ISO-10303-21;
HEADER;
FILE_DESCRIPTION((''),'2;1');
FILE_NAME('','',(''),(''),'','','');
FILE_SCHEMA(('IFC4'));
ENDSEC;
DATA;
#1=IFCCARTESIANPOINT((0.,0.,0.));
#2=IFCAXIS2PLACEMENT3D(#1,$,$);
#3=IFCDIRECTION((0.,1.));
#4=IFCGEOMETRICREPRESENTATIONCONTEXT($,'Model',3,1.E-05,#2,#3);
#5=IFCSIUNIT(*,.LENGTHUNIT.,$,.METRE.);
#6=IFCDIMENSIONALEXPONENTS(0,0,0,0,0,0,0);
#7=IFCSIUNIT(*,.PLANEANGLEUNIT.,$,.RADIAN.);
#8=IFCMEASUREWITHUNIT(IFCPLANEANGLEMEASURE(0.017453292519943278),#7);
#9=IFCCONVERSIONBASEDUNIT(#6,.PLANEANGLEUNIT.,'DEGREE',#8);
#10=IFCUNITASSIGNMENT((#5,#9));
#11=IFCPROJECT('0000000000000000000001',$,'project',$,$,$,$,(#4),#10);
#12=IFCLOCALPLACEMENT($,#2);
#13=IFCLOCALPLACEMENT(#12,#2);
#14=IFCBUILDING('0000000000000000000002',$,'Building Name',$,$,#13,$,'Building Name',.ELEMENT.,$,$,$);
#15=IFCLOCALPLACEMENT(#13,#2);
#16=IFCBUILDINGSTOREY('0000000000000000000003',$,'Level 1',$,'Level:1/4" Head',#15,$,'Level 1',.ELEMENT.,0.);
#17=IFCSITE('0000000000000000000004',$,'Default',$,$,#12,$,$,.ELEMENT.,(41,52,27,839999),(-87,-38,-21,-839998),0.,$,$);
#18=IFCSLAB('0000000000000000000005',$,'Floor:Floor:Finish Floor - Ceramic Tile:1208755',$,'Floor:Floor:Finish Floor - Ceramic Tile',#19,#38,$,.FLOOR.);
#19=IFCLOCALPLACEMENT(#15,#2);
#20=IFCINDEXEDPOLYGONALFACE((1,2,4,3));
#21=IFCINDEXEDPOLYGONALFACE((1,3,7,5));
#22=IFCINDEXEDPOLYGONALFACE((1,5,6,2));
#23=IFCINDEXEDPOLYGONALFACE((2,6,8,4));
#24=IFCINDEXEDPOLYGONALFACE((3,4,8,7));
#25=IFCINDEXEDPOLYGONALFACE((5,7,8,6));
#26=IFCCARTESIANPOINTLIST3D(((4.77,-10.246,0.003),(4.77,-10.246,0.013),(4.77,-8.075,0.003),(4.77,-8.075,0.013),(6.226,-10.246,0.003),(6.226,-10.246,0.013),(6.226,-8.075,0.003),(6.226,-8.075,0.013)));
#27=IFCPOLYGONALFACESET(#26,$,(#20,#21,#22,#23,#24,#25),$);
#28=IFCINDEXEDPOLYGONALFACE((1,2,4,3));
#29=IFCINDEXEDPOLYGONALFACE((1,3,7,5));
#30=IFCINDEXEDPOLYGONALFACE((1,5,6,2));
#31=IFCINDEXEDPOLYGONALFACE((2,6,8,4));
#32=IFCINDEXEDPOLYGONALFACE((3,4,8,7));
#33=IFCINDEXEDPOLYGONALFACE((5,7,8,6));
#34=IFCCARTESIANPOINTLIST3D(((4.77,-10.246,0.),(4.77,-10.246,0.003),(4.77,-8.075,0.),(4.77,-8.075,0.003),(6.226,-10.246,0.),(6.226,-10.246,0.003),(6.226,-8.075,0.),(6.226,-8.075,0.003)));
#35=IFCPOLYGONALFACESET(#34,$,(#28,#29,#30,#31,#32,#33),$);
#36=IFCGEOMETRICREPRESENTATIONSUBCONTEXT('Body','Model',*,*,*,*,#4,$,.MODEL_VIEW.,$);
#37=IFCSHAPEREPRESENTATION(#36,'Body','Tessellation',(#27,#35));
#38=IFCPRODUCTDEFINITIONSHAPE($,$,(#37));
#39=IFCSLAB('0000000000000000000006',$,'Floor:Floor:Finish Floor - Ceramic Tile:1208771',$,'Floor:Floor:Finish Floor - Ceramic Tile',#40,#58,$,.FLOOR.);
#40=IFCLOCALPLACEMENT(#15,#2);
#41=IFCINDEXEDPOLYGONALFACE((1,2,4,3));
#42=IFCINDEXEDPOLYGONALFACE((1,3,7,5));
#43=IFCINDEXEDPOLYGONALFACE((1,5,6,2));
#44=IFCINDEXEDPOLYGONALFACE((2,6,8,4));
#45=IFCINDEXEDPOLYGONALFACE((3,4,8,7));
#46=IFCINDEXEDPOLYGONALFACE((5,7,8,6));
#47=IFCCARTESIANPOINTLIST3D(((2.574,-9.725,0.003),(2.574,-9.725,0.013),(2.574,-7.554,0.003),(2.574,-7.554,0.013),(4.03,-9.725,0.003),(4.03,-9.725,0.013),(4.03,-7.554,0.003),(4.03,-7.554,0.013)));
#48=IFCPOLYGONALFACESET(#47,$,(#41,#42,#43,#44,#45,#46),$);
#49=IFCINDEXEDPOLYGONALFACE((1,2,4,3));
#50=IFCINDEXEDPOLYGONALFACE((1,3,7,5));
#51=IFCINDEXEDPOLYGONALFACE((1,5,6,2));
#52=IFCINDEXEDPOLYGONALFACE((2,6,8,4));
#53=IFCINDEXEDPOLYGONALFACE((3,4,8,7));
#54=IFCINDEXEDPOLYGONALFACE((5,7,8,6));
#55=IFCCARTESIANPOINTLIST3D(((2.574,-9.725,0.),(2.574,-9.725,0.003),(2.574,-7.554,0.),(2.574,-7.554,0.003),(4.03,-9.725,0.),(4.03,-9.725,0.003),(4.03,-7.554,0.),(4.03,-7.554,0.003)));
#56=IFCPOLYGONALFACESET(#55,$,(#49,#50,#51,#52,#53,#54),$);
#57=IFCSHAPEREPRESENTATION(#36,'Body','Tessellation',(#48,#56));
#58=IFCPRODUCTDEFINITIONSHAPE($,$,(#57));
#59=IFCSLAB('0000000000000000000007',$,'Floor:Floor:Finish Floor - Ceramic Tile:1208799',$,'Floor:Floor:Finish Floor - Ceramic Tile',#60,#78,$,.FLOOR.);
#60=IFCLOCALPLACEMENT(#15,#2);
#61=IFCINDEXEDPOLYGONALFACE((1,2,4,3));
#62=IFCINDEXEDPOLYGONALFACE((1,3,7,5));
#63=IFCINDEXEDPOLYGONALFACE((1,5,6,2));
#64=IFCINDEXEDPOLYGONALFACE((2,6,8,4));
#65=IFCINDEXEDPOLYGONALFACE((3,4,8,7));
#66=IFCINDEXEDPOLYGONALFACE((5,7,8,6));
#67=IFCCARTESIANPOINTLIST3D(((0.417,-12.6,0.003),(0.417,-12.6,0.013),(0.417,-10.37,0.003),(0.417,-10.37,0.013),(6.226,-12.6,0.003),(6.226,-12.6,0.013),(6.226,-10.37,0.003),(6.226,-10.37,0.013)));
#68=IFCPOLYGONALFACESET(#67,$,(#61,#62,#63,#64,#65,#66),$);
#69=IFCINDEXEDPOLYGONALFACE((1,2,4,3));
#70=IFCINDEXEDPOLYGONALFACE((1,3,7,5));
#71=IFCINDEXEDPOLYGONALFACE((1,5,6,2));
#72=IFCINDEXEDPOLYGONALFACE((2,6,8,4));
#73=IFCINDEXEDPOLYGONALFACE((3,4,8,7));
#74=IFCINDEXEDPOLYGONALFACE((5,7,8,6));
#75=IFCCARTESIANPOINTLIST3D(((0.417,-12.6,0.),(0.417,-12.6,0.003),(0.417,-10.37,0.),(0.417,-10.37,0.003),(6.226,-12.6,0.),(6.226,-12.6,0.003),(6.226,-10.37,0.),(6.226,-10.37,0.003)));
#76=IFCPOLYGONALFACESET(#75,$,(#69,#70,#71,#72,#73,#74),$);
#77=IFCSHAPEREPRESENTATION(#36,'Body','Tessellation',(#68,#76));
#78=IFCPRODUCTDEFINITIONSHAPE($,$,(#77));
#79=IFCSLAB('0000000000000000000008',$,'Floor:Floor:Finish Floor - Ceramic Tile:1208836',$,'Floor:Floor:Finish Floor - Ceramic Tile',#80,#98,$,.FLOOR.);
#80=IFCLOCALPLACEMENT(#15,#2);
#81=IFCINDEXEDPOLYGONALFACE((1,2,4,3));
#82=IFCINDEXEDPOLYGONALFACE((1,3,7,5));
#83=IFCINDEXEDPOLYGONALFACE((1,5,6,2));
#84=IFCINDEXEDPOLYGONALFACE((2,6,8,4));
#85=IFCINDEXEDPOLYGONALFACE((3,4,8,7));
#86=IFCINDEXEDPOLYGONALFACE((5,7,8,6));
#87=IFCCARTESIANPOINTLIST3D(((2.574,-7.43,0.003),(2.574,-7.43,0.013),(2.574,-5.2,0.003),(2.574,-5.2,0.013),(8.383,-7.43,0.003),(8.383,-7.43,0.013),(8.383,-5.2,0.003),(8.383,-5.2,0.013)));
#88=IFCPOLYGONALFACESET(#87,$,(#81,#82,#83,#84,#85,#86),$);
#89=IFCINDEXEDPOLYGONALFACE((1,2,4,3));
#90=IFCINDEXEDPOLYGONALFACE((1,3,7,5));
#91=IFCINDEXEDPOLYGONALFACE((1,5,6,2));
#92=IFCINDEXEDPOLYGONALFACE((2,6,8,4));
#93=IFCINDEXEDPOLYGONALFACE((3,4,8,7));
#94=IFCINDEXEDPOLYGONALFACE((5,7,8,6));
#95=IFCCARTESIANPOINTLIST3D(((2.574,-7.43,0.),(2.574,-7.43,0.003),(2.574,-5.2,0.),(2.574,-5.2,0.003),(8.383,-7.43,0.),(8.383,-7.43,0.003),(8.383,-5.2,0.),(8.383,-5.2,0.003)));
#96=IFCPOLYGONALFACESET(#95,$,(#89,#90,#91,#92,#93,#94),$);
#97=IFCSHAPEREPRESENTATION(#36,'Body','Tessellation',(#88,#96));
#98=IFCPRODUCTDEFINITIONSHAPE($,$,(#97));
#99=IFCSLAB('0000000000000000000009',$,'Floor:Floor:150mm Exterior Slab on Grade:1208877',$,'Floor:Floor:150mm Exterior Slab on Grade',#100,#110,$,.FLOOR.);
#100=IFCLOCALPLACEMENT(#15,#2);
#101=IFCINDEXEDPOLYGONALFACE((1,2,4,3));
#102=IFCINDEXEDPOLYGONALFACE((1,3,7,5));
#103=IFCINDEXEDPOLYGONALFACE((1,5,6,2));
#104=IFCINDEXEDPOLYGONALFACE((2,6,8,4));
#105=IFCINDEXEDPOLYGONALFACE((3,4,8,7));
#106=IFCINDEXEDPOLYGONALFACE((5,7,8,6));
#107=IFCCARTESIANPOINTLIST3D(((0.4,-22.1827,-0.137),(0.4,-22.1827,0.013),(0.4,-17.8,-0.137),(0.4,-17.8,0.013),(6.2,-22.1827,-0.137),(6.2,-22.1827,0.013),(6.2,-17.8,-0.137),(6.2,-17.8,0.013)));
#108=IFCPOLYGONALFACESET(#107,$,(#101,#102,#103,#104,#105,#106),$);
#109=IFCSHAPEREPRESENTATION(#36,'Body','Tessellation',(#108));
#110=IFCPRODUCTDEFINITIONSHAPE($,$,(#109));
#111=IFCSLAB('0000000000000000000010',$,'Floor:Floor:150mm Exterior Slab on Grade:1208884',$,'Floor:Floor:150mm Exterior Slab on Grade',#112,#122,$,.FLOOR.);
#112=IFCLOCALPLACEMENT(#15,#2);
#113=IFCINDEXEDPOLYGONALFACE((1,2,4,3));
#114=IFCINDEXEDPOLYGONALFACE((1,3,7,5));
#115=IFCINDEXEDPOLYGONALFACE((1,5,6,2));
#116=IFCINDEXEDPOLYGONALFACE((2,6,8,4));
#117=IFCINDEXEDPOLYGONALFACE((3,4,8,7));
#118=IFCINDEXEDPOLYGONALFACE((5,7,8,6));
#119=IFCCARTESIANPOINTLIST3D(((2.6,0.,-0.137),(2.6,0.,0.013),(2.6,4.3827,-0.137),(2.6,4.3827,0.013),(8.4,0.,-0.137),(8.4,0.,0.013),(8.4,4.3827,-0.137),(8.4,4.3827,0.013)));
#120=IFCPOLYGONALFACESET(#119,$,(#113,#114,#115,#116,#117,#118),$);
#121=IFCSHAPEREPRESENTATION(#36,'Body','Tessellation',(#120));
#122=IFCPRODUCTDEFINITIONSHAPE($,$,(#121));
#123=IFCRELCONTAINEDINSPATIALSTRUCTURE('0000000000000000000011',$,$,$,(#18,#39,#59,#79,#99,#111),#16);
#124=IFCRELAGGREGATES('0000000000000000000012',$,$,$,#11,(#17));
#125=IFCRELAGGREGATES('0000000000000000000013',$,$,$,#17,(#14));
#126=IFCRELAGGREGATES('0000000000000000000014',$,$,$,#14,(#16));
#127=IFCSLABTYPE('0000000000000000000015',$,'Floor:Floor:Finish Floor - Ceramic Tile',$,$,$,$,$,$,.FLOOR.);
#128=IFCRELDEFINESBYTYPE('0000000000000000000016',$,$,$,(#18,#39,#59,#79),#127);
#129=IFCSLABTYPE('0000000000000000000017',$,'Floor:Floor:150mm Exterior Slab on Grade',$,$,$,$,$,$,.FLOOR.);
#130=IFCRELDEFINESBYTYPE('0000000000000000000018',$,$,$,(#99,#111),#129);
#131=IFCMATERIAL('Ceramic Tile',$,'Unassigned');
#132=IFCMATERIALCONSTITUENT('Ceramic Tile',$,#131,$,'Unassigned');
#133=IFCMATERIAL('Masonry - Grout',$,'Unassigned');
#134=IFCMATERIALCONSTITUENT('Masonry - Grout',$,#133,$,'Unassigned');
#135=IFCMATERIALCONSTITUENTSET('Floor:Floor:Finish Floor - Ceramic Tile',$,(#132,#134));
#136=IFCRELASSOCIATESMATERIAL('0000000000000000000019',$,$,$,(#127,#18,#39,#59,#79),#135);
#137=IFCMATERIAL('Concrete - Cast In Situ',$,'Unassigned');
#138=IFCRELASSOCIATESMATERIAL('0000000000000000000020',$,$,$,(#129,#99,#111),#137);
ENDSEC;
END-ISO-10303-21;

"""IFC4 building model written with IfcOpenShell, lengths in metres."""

from ifc_helpers import new_model, entity, si_unit, converted_unit, direction, frame, origin, place, context, subcontext, project, spatial, indexed_curve, outline, extrude, material, constituent, constituent_set, type_object, element, save


model = new_model("IFC4")

# Units and contexts
model_context = context("Model", 3, precision=1e-05, world=origin(), true_north=direction((0.0, 1.0)))
body_context = subcontext(model_context, "Body", "Model", "MODEL_VIEW")
ifc_project = project(units=[si_unit("LENGTHUNIT", "METRE"), converted_unit("PLANEANGLEUNIT", "DEGREE", entity("IfcPlaneAngleMeasure", 0.017453292519943278), si_unit("PLANEANGLEUNIT", "RADIAN"), dimensions=[0, 0, 0, 0, 0, 0, 0])], contexts=[model_context])

# Site, building, storey
site_placement = place(None, origin())
site = spatial("IfcSite", under=ifc_project, at=site_placement, Name="Default", CompositionType="ELEMENT", RefLatitude=(41, 52, 27, 839999), RefLongitude=(-87, -38, -21, -839998), RefElevation=0.0)
building_placement = place(site_placement, origin())
building = spatial("IfcBuilding", under=site, at=building_placement, Name="Building Name", LongName="Building Name", CompositionType="ELEMENT")
storey_placement = place(building_placement, origin())
storey = spatial("IfcBuildingStorey", under=building, at=storey_placement, Name="Level 1", ObjectType="Level:1/4\" Head", LongName="Level 1", CompositionType="ELEMENT", Elevation=0.0)

# Slabs
ifc_material_1 = material(Name="Ceramic Tile", Category="Unassigned")
ifc_constituent_1 = constituent(ifc_material_1, Name="Ceramic Tile", Category="Unassigned")
ifc_material_2 = material(Name="Masonry - Grout", Category="Unassigned")
ifc_constituent_2 = constituent(ifc_material_2, Name="Masonry - Grout", Category="Unassigned")
ifc_constituent_set_1 = constituent_set(constituents=[ifc_constituent_1, ifc_constituent_2], Name="Floor:Floor:Finish Floor - Ceramic Tile")
slab_type_1 = type_object("IfcSlabType", Name="Floor:Floor:Finish Floor - Ceramic Tile", PredefinedType="FLOOR", material=ifc_constituent_set_1)
slab_1_placement = place(storey_placement, origin())
element("IfcSlab", 1, at=slab_1_placement, inside=storey, type_object=slab_type_1, material=ifc_constituent_set_1, Name="Floor:Floor:Finish Floor - Ceramic Tile:1208755", ObjectType="Floor:Floor:Finish Floor - Ceramic Tile", PredefinedType="FLOOR", context=body_context, shape_type="SweptSolid", body=[
    extrude(outline(indexed_curve([(-0.728, -1.0855), (0.728, -1.0855), (0.728, 1.0855), (-0.728, 1.0855), (-0.728, -1.0855)], self_intersect=False)), frame((5.498, -9.1605, 0.003), z_axis=(0.0, 0.0, 1.0), x_axis=(-1.0, 0.0, 0.0)), (0.0, 0.0, 1.0), 0.01),
    extrude(outline(indexed_curve([(-0.728, -1.0855), (0.728, -1.0855), (0.728, 1.0855), (-0.728, 1.0855), (-0.728, -1.0855)], self_intersect=False)), frame((5.498, -9.1605, 0.0), z_axis=(0.0, 0.0, 1.0), x_axis=(-1.0, 0.0, 0.0)), (0.0, 0.0, 1.0), 0.003),
])
slab_2_placement = place(storey_placement, origin())
element("IfcSlab", 2, at=slab_2_placement, inside=storey, type_object=slab_type_1, material=ifc_constituent_set_1, Name="Floor:Floor:Finish Floor - Ceramic Tile:1208771", ObjectType="Floor:Floor:Finish Floor - Ceramic Tile", PredefinedType="FLOOR", context=body_context, shape_type="SweptSolid", body=[
    extrude(outline(indexed_curve([(-1.0855, -0.728), (1.0855, -0.728), (1.0855, 0.728), (-1.0855, 0.728), (-1.0855, -0.728)], self_intersect=False)), frame((3.302, -8.6395, 0.003), z_axis=(0.0, 0.0, 1.0), x_axis=(0.0, 1.0, 0.0)), (0.0, 0.0, 1.0), 0.01),
    extrude(outline(indexed_curve([(-1.0855, -0.728), (1.0855, -0.728), (1.0855, 0.728), (-1.0855, 0.728), (-1.0855, -0.728)], self_intersect=False)), frame((3.302, -8.6395, 0.0), z_axis=(0.0, 0.0, 1.0), x_axis=(0.0, 1.0, 0.0)), (0.0, 0.0, 1.0), 0.003),
])
slab_3_placement = place(storey_placement, origin())
element("IfcSlab", 3, at=slab_3_placement, inside=storey, type_object=slab_type_1, material=ifc_constituent_set_1, Name="Floor:Floor:Finish Floor - Ceramic Tile:1208799", ObjectType="Floor:Floor:Finish Floor - Ceramic Tile", PredefinedType="FLOOR", context=body_context, shape_type="SweptSolid", body=[
    extrude(outline(indexed_curve([(-2.9045, -1.115), (2.9045, -1.115), (2.9045, 1.115), (-2.9045, 1.115), (-2.9045, -1.115)], self_intersect=False)), frame((3.3215, -11.485, 0.003), z_axis=(0.0, 0.0, 1.0), x_axis=(-1.0, 0.0, 0.0)), (0.0, 0.0, 1.0), 0.01),
    extrude(outline(indexed_curve([(-2.9045, -1.115), (2.9045, -1.115), (2.9045, 1.115), (-2.9045, 1.115), (-2.9045, -1.115)], self_intersect=False)), frame((3.3215, -11.485, 0.0), z_axis=(0.0, 0.0, 1.0), x_axis=(-1.0, 0.0, 0.0)), (0.0, 0.0, 1.0), 0.003),
])
slab_4_placement = place(storey_placement, origin())
element("IfcSlab", 4, at=slab_4_placement, inside=storey, type_object=slab_type_1, material=ifc_constituent_set_1, Name="Floor:Floor:Finish Floor - Ceramic Tile:1208836", ObjectType="Floor:Floor:Finish Floor - Ceramic Tile", PredefinedType="FLOOR", context=body_context, shape_type="SweptSolid", body=[
    extrude(outline(indexed_curve([(-2.9045, -1.115), (2.9045, -1.115), (2.9045, 1.115), (-2.9045, 1.115), (-2.9045, -1.115)], self_intersect=False)), frame((5.4785, -6.315, 0.003), z_axis=(0.0, 0.0, 1.0), x_axis=(-1.0, 0.0, 0.0)), (0.0, 0.0, 1.0), 0.01),
    extrude(outline(indexed_curve([(-2.9045, -1.115), (2.9045, -1.115), (2.9045, 1.115), (-2.9045, 1.115), (-2.9045, -1.115)], self_intersect=False)), frame((5.4785, -6.315, 0.0), z_axis=(0.0, 0.0, 1.0), x_axis=(-1.0, 0.0, 0.0)), (0.0, 0.0, 1.0), 0.003),
])
ifc_material_3 = material(Name="Concrete - Cast In Situ", Category="Unassigned")
slab_type_2 = type_object("IfcSlabType", Name="Floor:Floor:150mm Exterior Slab on Grade", PredefinedType="FLOOR", material=ifc_material_3)
slab_5_placement = place(storey_placement, origin())
element("IfcSlab", 5, at=slab_5_placement, inside=storey, type_object=slab_type_2, material=ifc_material_3, Name="Floor:Floor:150mm Exterior Slab on Grade:1208877", ObjectType="Floor:Floor:150mm Exterior Slab on Grade", PredefinedType="FLOOR", context=body_context, shape_type="SweptSolid", body=[
    extrude(outline(indexed_curve([(-2.1914, -2.9), (2.1914, -2.9), (2.1914, 2.9), (-2.1914, 2.9), (-2.1914, -2.9)], self_intersect=False)), frame((3.3, -19.9914, 0.013), z_axis=(0.0, 0.0, -1.0), x_axis=(0.0, 1.0, 0.0)), (0.0, 0.0, 1.0), 0.15),
])
slab_6_placement = place(storey_placement, origin())
element("IfcSlab", 6, at=slab_6_placement, inside=storey, type_object=slab_type_2, material=ifc_material_3, Name="Floor:Floor:150mm Exterior Slab on Grade:1208884", ObjectType="Floor:Floor:150mm Exterior Slab on Grade", PredefinedType="FLOOR", context=body_context, shape_type="SweptSolid", body=[
    extrude(outline(indexed_curve([(-2.1914, -2.9), (2.1914, -2.9), (2.1914, 2.9), (-2.1914, 2.9), (-2.1914, -2.9)], self_intersect=False)), frame((5.5, 2.1914, 0.013), z_axis=(0.0, 0.0, -1.0), x_axis=(0.0, 1.0, 0.0)), (0.0, 0.0, 1.0), 0.15),
])

save(model, "model.ifc")
